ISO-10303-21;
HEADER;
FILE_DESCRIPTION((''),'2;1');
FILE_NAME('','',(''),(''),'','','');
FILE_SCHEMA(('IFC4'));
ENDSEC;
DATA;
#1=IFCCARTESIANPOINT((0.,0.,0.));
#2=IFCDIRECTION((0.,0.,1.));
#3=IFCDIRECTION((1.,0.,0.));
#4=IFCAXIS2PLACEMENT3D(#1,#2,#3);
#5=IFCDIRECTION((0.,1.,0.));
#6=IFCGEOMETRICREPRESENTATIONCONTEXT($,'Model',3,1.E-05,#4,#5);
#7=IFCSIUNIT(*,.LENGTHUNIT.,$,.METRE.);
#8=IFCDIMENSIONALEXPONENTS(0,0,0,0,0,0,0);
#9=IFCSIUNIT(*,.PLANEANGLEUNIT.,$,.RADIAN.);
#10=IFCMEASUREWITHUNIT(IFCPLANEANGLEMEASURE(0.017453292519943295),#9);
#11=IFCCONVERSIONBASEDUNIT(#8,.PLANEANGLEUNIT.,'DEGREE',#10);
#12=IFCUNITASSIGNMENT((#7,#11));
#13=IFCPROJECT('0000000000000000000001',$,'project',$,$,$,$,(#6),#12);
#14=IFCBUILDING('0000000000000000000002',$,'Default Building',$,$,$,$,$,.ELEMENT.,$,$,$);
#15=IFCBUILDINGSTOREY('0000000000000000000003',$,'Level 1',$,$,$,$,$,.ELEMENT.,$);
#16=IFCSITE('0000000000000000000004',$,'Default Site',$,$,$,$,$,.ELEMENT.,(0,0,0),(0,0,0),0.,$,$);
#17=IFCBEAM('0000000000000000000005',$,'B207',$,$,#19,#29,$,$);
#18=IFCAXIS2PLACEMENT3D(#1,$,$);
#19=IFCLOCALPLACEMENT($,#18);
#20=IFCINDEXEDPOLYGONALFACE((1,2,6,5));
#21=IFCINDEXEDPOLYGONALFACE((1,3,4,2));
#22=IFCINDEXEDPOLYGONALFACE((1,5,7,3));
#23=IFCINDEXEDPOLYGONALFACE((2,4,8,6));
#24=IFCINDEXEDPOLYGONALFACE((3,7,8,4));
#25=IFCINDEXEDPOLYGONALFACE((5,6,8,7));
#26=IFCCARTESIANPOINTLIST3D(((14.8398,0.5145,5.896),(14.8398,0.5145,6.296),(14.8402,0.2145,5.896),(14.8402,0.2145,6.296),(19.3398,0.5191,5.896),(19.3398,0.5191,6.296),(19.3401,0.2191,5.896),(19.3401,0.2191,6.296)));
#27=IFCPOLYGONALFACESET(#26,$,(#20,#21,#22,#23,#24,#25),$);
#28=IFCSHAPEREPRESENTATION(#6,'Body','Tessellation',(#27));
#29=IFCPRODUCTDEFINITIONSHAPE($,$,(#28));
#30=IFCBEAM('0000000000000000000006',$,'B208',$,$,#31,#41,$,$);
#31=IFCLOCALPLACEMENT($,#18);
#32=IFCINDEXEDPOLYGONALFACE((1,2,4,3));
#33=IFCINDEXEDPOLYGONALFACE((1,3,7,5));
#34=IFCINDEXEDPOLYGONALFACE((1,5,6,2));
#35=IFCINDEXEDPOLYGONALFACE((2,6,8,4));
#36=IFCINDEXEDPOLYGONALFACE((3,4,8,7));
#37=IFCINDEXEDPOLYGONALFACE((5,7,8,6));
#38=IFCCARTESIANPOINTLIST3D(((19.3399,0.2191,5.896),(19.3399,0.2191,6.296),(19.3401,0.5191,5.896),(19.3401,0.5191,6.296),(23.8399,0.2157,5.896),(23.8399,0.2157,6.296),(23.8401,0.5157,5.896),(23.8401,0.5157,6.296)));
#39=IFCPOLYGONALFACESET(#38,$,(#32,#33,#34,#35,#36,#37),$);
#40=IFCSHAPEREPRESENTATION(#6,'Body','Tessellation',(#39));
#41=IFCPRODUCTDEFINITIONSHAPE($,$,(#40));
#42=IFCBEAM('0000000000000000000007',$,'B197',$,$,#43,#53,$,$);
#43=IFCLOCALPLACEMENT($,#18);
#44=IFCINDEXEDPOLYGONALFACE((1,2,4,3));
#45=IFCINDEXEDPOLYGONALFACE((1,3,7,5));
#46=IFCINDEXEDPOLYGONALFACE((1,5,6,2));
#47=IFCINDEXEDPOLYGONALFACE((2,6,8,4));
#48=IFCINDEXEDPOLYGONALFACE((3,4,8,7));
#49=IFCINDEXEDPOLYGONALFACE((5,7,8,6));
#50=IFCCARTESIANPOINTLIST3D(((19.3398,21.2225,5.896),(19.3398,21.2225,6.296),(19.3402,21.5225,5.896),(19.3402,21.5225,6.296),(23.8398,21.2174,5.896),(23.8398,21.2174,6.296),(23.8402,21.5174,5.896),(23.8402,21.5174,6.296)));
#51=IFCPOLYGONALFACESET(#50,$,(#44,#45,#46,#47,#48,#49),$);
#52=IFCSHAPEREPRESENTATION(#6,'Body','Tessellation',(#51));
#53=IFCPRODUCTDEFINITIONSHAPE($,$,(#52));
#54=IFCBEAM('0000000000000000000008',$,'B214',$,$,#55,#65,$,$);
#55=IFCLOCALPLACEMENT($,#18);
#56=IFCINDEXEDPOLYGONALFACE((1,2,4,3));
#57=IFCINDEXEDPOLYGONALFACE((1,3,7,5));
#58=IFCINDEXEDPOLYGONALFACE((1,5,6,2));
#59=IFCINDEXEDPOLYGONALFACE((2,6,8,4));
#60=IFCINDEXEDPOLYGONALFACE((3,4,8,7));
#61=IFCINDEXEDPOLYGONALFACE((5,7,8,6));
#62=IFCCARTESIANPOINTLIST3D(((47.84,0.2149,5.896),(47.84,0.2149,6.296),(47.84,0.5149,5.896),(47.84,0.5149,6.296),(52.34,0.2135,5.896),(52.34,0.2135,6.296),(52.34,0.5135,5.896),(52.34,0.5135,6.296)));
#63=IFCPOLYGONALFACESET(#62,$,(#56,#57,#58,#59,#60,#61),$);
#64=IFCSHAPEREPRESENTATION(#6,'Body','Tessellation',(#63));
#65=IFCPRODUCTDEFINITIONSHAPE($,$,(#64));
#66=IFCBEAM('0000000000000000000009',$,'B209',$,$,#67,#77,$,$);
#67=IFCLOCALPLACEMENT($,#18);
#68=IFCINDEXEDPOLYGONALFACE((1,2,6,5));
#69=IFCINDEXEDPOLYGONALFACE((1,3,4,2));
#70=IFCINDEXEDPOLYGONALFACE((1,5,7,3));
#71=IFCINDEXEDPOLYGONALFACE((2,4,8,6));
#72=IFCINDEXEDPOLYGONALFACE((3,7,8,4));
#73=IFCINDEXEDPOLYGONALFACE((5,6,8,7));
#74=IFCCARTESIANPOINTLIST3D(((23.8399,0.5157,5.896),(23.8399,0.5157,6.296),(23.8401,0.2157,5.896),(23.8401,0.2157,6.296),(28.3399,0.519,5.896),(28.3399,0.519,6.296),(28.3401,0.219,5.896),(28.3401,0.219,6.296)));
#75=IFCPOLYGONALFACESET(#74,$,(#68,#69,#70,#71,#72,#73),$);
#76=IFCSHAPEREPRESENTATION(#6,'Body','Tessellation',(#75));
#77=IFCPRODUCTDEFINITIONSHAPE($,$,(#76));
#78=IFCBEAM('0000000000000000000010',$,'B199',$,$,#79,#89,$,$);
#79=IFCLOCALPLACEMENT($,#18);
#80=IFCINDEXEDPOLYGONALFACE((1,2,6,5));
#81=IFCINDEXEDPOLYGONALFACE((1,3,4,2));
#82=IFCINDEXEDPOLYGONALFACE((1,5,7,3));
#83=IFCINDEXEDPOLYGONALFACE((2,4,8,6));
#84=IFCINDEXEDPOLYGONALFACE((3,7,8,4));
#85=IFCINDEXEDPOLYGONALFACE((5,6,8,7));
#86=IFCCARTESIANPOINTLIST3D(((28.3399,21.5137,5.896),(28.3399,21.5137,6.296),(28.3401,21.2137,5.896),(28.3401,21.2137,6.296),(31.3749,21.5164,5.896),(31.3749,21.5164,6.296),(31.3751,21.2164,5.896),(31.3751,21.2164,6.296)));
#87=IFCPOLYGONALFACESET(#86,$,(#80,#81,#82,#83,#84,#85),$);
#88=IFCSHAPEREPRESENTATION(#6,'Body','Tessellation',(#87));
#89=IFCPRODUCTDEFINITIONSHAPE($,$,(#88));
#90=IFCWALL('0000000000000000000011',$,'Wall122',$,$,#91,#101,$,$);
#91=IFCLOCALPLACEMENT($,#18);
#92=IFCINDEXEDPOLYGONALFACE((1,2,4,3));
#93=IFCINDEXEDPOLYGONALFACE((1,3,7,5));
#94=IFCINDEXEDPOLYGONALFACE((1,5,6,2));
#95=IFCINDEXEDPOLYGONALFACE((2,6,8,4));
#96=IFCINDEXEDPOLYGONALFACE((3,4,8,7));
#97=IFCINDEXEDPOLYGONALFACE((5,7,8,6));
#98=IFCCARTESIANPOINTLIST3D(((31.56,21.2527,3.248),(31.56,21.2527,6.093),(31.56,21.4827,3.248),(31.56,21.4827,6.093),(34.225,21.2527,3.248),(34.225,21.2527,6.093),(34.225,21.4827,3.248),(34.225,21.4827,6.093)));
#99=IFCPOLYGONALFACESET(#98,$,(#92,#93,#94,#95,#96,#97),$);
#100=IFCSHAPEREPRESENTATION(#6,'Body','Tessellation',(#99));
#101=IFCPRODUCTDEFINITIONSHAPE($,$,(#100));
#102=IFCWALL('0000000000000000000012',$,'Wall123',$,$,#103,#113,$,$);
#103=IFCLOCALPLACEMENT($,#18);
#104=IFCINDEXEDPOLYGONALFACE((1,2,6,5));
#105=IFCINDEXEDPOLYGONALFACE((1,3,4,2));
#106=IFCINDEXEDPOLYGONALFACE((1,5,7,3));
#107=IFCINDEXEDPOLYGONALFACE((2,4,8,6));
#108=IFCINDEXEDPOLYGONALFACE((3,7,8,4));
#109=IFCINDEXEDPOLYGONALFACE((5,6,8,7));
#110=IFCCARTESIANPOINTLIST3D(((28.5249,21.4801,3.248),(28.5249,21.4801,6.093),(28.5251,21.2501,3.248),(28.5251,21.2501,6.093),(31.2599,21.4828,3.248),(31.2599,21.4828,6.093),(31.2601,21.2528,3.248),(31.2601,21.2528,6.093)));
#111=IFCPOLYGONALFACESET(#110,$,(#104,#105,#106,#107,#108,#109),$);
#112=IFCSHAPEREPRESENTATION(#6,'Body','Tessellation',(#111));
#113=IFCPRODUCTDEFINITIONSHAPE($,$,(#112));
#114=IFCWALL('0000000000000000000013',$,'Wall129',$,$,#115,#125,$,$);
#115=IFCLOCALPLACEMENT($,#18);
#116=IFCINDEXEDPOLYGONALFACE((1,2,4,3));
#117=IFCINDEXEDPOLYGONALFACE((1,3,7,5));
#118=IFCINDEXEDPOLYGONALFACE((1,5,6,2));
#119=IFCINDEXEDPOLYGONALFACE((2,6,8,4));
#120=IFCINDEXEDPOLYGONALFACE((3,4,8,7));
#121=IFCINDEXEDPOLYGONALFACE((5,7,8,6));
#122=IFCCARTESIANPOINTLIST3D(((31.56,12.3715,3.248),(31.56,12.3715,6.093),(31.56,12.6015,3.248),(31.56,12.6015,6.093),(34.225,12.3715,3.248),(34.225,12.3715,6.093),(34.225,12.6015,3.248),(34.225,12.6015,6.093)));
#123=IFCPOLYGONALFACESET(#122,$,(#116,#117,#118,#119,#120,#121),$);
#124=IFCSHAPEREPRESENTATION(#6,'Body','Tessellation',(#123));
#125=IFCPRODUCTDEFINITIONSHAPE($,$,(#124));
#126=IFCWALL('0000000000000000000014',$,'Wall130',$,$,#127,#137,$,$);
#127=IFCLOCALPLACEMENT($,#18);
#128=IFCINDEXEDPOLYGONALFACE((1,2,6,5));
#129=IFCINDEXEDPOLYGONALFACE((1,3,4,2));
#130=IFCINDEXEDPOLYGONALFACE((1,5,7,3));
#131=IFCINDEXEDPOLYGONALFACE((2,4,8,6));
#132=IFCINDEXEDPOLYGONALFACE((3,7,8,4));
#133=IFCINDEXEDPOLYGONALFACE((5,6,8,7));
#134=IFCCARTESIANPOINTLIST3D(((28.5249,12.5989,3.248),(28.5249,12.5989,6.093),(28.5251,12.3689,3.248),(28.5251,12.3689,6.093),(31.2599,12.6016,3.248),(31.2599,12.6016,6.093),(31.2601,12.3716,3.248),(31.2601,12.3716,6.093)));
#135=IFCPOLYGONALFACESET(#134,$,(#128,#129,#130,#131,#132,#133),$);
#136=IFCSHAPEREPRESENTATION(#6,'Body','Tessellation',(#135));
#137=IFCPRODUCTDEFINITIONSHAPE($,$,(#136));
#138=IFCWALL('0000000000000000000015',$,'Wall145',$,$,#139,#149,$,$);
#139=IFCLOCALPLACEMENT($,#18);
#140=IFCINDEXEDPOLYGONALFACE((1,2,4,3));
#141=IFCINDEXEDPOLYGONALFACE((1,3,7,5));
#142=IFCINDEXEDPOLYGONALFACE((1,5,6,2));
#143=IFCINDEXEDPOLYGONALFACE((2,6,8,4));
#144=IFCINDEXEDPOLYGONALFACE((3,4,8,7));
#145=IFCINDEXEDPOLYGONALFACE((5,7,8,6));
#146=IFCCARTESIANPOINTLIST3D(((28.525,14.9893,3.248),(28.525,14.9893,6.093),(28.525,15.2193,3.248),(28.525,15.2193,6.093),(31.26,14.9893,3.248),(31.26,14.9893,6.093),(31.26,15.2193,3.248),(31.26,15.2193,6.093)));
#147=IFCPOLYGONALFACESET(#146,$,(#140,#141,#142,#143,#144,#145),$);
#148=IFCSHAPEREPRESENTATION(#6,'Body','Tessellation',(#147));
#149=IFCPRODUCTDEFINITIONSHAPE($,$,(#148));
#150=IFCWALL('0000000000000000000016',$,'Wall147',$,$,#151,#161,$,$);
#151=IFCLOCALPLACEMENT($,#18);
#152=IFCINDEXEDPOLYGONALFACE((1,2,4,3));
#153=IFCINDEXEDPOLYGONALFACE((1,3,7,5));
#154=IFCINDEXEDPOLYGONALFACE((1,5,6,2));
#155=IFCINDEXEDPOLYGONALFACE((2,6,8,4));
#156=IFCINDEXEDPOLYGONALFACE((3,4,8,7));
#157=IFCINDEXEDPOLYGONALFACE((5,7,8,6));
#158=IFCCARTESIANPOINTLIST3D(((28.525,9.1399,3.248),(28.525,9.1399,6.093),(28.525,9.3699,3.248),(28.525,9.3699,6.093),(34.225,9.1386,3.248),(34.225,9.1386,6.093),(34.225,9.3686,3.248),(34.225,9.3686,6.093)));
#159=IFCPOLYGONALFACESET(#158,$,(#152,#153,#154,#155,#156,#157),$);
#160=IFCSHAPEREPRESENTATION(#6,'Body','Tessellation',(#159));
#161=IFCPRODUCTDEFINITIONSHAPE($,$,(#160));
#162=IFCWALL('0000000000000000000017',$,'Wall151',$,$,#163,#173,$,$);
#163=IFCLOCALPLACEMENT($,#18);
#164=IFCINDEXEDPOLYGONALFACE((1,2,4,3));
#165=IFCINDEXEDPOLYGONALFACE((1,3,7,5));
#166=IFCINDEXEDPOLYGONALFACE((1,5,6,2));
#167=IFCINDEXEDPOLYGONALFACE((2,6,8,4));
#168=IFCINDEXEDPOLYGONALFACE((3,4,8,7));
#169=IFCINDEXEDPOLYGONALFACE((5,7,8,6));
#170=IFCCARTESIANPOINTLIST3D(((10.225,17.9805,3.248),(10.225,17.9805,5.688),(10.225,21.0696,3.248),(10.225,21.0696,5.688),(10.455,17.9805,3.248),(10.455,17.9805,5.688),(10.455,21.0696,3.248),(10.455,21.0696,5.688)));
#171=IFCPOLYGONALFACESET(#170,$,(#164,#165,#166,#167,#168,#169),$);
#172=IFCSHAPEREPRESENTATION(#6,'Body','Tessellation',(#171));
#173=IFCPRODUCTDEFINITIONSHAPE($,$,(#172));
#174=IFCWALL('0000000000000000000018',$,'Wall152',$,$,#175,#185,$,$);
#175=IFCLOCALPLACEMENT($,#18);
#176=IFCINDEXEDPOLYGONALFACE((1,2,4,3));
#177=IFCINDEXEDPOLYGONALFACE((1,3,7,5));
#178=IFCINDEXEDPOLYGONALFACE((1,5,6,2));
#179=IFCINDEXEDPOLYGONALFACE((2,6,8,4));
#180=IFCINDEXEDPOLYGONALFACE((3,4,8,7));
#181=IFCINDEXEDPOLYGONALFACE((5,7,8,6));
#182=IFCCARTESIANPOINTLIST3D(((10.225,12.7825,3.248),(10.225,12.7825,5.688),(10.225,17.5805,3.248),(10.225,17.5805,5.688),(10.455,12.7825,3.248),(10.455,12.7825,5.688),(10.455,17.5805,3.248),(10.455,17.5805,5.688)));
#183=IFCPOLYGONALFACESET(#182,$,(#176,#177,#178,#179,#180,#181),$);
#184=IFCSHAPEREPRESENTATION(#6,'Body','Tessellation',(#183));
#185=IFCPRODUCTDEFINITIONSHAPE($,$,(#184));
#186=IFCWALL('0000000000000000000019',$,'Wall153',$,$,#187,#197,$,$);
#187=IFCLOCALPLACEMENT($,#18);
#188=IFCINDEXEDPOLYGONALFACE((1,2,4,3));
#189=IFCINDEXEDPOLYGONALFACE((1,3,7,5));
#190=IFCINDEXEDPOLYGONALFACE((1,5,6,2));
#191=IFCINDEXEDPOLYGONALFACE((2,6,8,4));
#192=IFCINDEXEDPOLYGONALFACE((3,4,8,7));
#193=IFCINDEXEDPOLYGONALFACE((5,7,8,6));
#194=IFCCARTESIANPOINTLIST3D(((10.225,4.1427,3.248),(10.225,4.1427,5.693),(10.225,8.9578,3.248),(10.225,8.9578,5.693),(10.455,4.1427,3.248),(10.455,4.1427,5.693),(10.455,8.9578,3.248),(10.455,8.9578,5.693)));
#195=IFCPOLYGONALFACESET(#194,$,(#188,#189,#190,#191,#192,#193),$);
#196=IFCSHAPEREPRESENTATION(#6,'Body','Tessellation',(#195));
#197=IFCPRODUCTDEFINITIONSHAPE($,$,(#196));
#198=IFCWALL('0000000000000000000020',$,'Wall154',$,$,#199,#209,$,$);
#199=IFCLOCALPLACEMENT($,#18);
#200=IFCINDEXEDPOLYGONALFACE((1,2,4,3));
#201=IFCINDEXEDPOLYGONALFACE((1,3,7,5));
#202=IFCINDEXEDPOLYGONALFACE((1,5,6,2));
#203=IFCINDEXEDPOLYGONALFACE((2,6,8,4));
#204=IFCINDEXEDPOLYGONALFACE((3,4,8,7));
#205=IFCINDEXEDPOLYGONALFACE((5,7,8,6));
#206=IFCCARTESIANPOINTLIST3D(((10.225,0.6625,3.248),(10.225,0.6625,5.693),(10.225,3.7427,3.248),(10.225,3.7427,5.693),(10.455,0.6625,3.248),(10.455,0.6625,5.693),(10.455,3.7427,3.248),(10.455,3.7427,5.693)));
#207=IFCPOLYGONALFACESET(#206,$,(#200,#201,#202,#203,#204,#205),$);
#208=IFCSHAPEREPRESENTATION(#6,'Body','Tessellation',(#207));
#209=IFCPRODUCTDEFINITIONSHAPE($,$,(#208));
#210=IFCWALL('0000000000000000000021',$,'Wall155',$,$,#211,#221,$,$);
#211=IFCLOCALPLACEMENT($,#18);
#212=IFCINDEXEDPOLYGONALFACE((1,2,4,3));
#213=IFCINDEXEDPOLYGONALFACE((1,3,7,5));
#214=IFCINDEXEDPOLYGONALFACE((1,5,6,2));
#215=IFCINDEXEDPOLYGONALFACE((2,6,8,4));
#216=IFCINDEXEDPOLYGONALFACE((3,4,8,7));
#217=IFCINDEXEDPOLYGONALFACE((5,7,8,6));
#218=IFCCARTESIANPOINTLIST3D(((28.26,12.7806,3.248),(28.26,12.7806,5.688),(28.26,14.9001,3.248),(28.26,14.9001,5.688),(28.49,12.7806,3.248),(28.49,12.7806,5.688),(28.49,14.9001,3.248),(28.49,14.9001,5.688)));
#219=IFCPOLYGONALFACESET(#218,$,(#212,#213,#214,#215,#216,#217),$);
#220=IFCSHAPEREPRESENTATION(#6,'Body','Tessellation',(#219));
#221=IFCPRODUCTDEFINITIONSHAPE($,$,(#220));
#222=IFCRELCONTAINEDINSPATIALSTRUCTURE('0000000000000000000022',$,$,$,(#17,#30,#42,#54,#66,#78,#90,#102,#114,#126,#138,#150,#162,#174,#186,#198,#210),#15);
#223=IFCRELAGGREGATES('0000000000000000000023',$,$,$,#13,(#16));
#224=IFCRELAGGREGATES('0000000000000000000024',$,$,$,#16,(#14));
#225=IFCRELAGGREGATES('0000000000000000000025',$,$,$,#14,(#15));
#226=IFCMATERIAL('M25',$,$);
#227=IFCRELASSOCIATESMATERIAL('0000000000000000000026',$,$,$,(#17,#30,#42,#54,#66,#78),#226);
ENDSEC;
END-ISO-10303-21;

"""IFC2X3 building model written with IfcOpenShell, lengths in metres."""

from ifc_helpers import new_model, entity, si_unit, converted_unit, direction, frame, frame_2d, origin_with_axes, place, context, project, spatial, rectangle, extrude, material, element, save


model = new_model("IFC2X3")

# Units and contexts
model_context = context("Model", 3, precision=1e-05, world=origin_with_axes(), true_north=direction((0.0, 1.0, 0.0)))
ifc_project = project(units=[si_unit("LENGTHUNIT", "METRE"), converted_unit("PLANEANGLEUNIT", "DEGREE", entity("IfcPlaneAngleMeasure", 0.017453292519943295), si_unit("PLANEANGLEUNIT", "RADIAN"), dimensions=[0, 0, 0, 0, 0, 0, 0])], contexts=[model_context])

# Site, building, storey
site = spatial("IfcSite", under=ifc_project, Name="Default Site", CompositionType="ELEMENT", RefLatitude=(0, 0, 0), RefLongitude=(0, 0, 0), RefElevation=0.0)
building = spatial("IfcBuilding", under=site, Name="Default Building", CompositionType="ELEMENT")
storey = spatial("IfcBuildingStorey", under=building, Name="Level 1", CompositionType="ELEMENT")

# Beams
ifc_material = material(Name="M25")
placement = place(None, origin_with_axes())
element("IfcBeam", 1, at=placement, inside=storey, material=ifc_material, Name="B207", context=model_context, shape_type="SweptSolid", body=[
    extrude(rectangle(XDim=0.3, YDim=0.4, at=frame_2d((0.0, 0.0), x_axis=(0.0, 1.0, 0.0))), frame((14.84, 0.3645, 6.096), z_axis=(0.999999, 0.00101, 0.0), x_axis=(0.0, 0.0, -1.0)), (0.0, 0.0, 1.0), 4.5),
])
element("IfcBeam", 2, at=placement, inside=storey, material=ifc_material, Name="B208", context=model_context, shape_type="SweptSolid", body=[
    extrude(rectangle(XDim=0.3, YDim=0.4, at=frame_2d((0.0, 0.0), x_axis=(0.0, 1.0, 0.0))), frame((19.34, 0.3691, 6.096), z_axis=(1.0, -0.000757, 0.0), x_axis=(0.0, 0.0, -1.0)), (0.0, 0.0, 1.0), 4.5),
])
element("IfcBeam", 3, at=placement, inside=storey, material=ifc_material, Name="B197", context=model_context, shape_type="SweptSolid", body=[
    extrude(rectangle(XDim=0.3, YDim=0.4, at=frame_2d((0.0, 0.0), x_axis=(0.0, 1.0, 0.0))), frame((19.34, 21.3725, 6.096), z_axis=(0.999999, -0.001141, 0.0), x_axis=(0.0, 0.0, -1.0)), (0.0, 0.0, 1.0), 4.5),
])
element("IfcBeam", 4, at=placement, inside=storey, material=ifc_material, Name="B214", context=model_context, shape_type="SweptSolid", body=[
    extrude(rectangle(XDim=0.3, YDim=0.4, at=frame_2d((0.0, 0.0), x_axis=(0.0, 1.0, 0.0))), frame((47.84, 0.3649, 6.096), z_axis=(1.0, -0.000297, 0.0), x_axis=(0.0, 0.0, -1.0)), (0.0, 0.0, 1.0), 4.5),
])
element("IfcBeam", 5, at=placement, inside=storey, material=ifc_material, Name="B209", context=model_context, shape_type="SweptSolid", body=[
    extrude(rectangle(XDim=0.3, YDim=0.4, at=frame_2d((0.0, 0.0), x_axis=(0.0, 1.0, 0.0))), frame((23.84, 0.3657, 6.096), z_axis=(1.0, 0.00075, 0.0), x_axis=(0.0, 0.0, -1.0)), (0.0, 0.0, 1.0), 4.5),
])
element("IfcBeam", 6, at=placement, inside=storey, material=ifc_material, Name="B199", context=model_context, shape_type="SweptSolid", body=[
    extrude(rectangle(XDim=0.3, YDim=0.4, at=frame_2d((0.0, 0.0), x_axis=(0.0, 1.0, 0.0))), frame((28.34, 21.3637, 6.096), z_axis=(1.0, 0.000883, 0.0), x_axis=(0.0, 0.0, -1.0)), (0.0, 0.0, 1.0), 3.035),
])

# Walls
element("IfcWall", 7, at=placement, inside=storey, Name="Wall122", context=model_context, shape_type="SweptSolid", body=[
    extrude(rectangle(XDim=2.665, YDim=0.23, at=frame_2d((0.0, 0.0), x_axis=(-1.0, 0.0, 0.0))), frame((32.8925, 21.3677, 3.248), z_axis=(0.0, 0.0, 1.0), x_axis=(1.0, 0.0, 0.0)), (0.0, 0.0, 1.0), 2.845),
])
element("IfcWall", 8, at=placement, inside=storey, Name="Wall123", context=model_context, shape_type="SweptSolid", body=[
    extrude(rectangle(XDim=2.735, YDim=0.23, at=frame_2d((0.0, 0.0), x_axis=(-1.0, -0.00098, 0.0))), frame((29.8925, 21.3664, 3.248), z_axis=(0.0, 0.0, 1.0), x_axis=(1.0, 0.0, 0.0)), (0.0, 0.0, 1.0), 2.845),
])
element("IfcWall", 9, at=placement, inside=storey, Name="Wall129", context=model_context, shape_type="SweptSolid", body=[
    extrude(rectangle(XDim=2.665, YDim=0.23, at=frame_2d((0.0, 0.0), x_axis=(-1.0, 0.0, 0.0))), frame((32.8925, 12.4865, 3.248), z_axis=(0.0, 0.0, 1.0), x_axis=(1.0, 0.0, 0.0)), (0.0, 0.0, 1.0), 2.845),
])
element("IfcWall", 10, at=placement, inside=storey, Name="Wall130", context=model_context, shape_type="SweptSolid", body=[
    extrude(rectangle(XDim=2.735, YDim=0.23, at=frame_2d((0.0, 0.0), x_axis=(-1.0, -0.00098, 0.0))), frame((29.8925, 12.4852, 3.248), z_axis=(0.0, 0.0, 1.0), x_axis=(1.0, 0.0, 0.0)), (0.0, 0.0, 1.0), 2.845),
])
element("IfcWall", 11, at=placement, inside=storey, Name="Wall145", context=model_context, shape_type="SweptSolid", body=[
    extrude(rectangle(XDim=2.735, YDim=0.23, at=frame_2d((0.0, 0.0), x_axis=(-1.0, 0.0, 0.0))), frame((29.8925, 15.1043, 3.248), z_axis=(0.0, 0.0, 1.0), x_axis=(1.0, 0.0, 0.0)), (0.0, 0.0, 1.0), 2.845),
])
element("IfcWall", 12, at=placement, inside=storey, Name="Wall147", context=model_context, shape_type="SweptSolid", body=[
    extrude(rectangle(XDim=5.7, YDim=0.23, at=frame_2d((0.0, 0.0), x_axis=(1.0, -0.000224, 0.0))), frame((31.375, 9.2543, 3.248), z_axis=(0.0, 0.0, 1.0), x_axis=(1.0, 0.0, 0.0)), (0.0, 0.0, 1.0), 2.845),
])
element("IfcWall", 13, at=placement, inside=storey, Name="Wall151", context=model_context, shape_type="SweptSolid", body=[
    extrude(rectangle(XDim=3.0891, YDim=0.23, at=frame_2d((0.0, 0.0), x_axis=(0.0, -1.0, 0.0))), frame((10.34, 19.5251, 3.248), z_axis=(0.0, 0.0, 1.0), x_axis=(1.0, 0.0, 0.0)), (0.0, 0.0, 1.0), 2.44),
])
element("IfcWall", 14, at=placement, inside=storey, Name="Wall152", context=model_context, shape_type="SweptSolid", body=[
    extrude(rectangle(XDim=4.798, YDim=0.23, at=frame_2d((0.0, 0.0), x_axis=(0.0, -1.0, 0.0))), frame((10.34, 15.1815, 3.248), z_axis=(0.0, 0.0, 1.0), x_axis=(1.0, 0.0, 0.0)), (0.0, 0.0, 1.0), 2.44),
])
element("IfcWall", 15, at=placement, inside=storey, Name="Wall153", context=model_context, shape_type="SweptSolid", body=[
    extrude(rectangle(XDim=4.8151, YDim=0.23, at=frame_2d((0.0, 0.0), x_axis=(0.0, -1.0, 0.0))), frame((10.34, 6.5502, 3.248), z_axis=(0.0, 0.0, 1.0), x_axis=(1.0, 0.0, 0.0)), (0.0, 0.0, 1.0), 2.445),
])
element("IfcWall", 16, at=placement, inside=storey, Name="Wall154", context=model_context, shape_type="SweptSolid", body=[
    extrude(rectangle(XDim=3.0802, YDim=0.23, at=frame_2d((0.0, 0.0), x_axis=(0.0, -1.0, 0.0))), frame((10.34, 2.2026, 3.248), z_axis=(0.0, 0.0, 1.0), x_axis=(1.0, 0.0, 0.0)), (0.0, 0.0, 1.0), 2.445),
])
element("IfcWall", 17, at=placement, inside=storey, Name="Wall155", context=model_context, shape_type="SweptSolid", body=[
    extrude(rectangle(XDim=2.1195, YDim=0.23, at=frame_2d((0.0, 0.0), x_axis=(0.0, -1.0, 0.0))), frame((28.375, 13.8403, 3.248), z_axis=(0.0, 0.0, 1.0), x_axis=(1.0, 0.0, 0.0)), (0.0, 0.0, 1.0), 2.44),
])

save(model, "model.ifc")
